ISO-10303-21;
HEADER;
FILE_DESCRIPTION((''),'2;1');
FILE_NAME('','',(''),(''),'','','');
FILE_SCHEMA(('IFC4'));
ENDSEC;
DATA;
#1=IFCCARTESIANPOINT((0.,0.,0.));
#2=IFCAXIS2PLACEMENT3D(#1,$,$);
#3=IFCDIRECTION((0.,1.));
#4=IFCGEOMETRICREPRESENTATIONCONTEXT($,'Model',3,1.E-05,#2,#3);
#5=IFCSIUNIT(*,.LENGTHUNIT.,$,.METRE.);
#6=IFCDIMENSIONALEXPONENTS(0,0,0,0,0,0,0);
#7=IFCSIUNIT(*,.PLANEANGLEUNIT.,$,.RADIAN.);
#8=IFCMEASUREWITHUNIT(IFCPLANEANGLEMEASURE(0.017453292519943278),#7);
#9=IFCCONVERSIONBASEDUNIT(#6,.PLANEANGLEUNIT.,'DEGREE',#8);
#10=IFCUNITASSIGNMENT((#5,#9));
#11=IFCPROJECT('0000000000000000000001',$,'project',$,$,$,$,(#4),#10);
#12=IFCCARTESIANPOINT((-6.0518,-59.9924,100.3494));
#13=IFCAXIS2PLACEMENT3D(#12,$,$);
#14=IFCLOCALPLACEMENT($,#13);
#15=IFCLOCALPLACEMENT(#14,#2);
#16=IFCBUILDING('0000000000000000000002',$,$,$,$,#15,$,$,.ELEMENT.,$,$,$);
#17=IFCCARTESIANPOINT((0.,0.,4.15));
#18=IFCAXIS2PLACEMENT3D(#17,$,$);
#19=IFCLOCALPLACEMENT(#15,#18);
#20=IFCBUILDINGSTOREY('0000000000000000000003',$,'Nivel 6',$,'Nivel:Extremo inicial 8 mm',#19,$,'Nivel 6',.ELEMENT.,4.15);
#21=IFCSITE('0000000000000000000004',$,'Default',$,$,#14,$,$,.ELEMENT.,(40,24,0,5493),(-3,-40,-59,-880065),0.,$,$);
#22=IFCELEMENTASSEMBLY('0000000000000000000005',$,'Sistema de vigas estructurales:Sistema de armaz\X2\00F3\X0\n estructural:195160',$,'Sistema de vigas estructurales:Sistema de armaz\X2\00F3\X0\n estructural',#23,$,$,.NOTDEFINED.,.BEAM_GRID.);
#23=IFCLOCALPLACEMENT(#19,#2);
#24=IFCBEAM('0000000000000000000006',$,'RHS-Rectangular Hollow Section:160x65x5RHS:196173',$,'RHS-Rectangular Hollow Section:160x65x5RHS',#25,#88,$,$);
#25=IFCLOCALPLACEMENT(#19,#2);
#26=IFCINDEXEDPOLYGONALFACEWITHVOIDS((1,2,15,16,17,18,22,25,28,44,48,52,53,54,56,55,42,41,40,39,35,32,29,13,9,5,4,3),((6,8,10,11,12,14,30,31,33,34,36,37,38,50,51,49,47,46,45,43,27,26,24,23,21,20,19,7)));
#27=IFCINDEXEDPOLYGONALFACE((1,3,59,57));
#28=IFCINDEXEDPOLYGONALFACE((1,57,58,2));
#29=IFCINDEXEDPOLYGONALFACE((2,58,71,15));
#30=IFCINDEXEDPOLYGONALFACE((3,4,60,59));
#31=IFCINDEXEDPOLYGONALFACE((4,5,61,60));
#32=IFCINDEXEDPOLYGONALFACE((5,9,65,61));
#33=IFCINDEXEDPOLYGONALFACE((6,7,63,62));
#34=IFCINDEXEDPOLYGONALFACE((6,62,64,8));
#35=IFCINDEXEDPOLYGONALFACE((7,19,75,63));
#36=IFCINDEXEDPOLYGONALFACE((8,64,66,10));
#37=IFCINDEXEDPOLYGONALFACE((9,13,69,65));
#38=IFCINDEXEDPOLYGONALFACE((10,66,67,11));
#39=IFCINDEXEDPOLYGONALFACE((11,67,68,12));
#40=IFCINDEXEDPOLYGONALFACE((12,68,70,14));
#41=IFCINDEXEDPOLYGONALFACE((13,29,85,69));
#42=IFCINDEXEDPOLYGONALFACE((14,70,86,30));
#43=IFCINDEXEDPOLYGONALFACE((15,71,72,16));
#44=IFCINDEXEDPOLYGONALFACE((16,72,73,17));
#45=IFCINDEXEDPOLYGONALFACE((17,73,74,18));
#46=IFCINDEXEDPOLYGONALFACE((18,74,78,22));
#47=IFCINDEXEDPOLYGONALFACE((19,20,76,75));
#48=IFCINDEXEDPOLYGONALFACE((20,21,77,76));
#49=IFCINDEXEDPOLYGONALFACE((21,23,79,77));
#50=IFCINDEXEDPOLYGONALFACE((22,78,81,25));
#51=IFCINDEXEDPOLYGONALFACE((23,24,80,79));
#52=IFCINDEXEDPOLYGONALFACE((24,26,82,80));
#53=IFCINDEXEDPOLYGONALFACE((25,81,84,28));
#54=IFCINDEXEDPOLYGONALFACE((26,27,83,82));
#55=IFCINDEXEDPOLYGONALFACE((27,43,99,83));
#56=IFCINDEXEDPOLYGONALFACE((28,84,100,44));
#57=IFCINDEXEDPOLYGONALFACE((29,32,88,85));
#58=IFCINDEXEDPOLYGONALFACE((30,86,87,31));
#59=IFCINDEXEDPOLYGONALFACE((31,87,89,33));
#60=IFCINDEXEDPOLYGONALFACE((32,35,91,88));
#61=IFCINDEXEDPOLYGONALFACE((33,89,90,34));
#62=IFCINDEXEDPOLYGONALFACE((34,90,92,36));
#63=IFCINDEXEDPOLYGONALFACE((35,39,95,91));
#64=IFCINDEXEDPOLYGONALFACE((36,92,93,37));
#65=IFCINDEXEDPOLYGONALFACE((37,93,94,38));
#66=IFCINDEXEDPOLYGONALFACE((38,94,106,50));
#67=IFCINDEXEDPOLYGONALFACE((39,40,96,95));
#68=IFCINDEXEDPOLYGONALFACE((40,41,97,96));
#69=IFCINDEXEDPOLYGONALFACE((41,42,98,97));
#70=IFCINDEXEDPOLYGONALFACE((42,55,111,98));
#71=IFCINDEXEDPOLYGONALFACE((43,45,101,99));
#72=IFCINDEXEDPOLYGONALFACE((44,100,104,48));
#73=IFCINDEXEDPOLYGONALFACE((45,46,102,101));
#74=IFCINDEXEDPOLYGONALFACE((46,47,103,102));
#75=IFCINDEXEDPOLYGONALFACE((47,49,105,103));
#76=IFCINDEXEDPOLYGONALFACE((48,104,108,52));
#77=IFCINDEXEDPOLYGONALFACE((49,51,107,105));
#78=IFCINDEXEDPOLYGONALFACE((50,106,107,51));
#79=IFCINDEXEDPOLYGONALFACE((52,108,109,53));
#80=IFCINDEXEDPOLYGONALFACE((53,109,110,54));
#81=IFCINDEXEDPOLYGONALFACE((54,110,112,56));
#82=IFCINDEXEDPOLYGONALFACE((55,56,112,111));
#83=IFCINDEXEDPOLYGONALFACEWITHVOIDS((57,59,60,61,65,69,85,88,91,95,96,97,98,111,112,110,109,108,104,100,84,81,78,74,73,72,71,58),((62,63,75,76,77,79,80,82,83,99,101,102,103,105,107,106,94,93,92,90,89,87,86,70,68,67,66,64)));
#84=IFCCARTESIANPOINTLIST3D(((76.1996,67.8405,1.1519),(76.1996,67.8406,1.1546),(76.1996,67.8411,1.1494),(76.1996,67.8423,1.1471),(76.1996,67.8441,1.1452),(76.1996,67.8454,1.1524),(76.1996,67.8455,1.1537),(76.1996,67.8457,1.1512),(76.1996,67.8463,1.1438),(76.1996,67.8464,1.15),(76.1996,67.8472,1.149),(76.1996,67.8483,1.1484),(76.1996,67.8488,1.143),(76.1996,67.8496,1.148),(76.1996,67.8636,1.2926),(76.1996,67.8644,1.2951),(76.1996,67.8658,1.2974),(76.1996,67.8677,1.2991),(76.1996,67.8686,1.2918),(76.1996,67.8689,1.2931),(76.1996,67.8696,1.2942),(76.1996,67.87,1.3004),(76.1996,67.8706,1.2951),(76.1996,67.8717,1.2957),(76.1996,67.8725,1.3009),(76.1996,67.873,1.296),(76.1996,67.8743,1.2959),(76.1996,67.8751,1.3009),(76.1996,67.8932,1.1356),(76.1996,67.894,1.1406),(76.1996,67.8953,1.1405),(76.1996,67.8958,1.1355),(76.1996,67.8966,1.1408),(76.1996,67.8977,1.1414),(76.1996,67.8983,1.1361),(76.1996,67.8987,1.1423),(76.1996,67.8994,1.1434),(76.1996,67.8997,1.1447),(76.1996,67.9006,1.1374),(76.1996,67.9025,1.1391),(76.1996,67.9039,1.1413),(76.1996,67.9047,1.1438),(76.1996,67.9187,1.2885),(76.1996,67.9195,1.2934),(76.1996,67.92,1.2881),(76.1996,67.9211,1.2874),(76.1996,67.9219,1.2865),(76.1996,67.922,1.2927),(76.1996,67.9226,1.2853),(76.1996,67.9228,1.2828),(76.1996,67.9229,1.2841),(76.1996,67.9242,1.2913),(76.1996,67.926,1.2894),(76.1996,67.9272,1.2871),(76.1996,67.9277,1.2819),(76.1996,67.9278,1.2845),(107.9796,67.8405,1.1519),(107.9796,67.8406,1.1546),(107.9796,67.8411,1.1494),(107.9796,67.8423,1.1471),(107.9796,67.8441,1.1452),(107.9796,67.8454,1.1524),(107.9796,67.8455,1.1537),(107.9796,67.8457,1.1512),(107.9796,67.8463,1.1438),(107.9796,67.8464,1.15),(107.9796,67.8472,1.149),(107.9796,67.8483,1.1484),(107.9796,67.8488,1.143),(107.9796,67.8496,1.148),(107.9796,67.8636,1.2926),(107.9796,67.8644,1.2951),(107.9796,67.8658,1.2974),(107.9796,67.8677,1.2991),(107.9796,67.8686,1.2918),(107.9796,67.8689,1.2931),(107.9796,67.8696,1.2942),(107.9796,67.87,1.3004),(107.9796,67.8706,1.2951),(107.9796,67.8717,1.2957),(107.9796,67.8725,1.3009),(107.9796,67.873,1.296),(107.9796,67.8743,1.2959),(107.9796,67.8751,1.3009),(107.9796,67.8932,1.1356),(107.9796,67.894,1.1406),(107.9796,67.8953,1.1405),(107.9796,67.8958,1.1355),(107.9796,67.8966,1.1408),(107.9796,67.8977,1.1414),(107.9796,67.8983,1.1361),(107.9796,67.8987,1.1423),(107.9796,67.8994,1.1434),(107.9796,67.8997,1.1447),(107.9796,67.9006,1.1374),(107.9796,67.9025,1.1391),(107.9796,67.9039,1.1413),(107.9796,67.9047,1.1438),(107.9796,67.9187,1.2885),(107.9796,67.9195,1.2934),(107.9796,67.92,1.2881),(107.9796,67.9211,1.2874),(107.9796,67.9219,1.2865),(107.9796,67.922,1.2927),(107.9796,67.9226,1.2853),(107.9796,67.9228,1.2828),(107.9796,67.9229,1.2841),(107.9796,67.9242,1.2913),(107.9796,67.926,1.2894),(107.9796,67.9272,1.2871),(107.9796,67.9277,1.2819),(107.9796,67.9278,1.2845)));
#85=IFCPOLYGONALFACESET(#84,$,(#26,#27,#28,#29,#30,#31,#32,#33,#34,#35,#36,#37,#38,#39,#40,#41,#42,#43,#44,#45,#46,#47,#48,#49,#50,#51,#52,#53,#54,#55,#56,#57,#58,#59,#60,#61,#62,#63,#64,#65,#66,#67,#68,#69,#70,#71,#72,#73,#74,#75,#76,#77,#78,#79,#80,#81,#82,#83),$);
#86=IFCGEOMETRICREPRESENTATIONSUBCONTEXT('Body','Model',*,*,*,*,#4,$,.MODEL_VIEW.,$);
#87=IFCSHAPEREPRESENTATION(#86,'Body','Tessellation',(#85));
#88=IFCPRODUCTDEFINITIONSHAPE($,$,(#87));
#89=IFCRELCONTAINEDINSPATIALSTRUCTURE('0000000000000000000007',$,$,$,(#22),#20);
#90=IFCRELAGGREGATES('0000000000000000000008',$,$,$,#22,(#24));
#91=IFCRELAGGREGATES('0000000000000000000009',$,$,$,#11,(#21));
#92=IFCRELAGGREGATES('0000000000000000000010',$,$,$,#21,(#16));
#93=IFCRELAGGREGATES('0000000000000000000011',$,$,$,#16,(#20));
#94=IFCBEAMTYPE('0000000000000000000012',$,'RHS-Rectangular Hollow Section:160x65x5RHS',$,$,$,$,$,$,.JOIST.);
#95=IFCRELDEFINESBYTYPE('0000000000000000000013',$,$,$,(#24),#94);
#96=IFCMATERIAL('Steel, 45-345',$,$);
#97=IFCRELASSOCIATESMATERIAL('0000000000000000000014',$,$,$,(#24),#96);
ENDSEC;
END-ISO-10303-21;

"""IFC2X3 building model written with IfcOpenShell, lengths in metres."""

from ifc_helpers import new_model, entity, si_unit, converted_unit, direction, frame, frame_2d, origin, place, context, subcontext, project, spatial, polyline, circle_curve, parameter, trimmed, segment, composite_curve, outline, extrude, material, type_object, element, aggregate, save


model = new_model("IFC2X3")

# Units and contexts
model_context = context("Model", 3, precision=1e-05, world=origin(), true_north=direction((0.0, 1.0)))
body_context = subcontext(model_context, "Body", "Model", "MODEL_VIEW")
ifc_project = project(units=[si_unit("LENGTHUNIT", "METRE"), converted_unit("PLANEANGLEUNIT", "DEGREE", entity("IfcPlaneAngleMeasure", 0.017453292519943278), si_unit("PLANEANGLEUNIT", "RADIAN"), dimensions=[0, 0, 0, 0, 0, 0, 0])], contexts=[model_context])

# Site, building, storey
site_placement = place(None, frame((-6.0518, -59.9924, 100.3494)))
site = spatial("IfcSite", under=ifc_project, at=site_placement, Name="Default", CompositionType="ELEMENT", RefLatitude=(40, 24, 0, 5493), RefLongitude=(-3, -40, -59, -880065), RefElevation=0.0)
building_placement = place(site_placement, origin())
building = spatial("IfcBuilding", under=site, at=building_placement, CompositionType="ELEMENT")
storey_placement = place(building_placement, frame((0.0, 0.0, 4.15)))
storey = spatial("IfcBuildingStorey", under=building, at=storey_placement, Name="Nivel 6", ObjectType="Nivel:Extremo inicial 8 mm", LongName="Nivel 6", CompositionType="ELEMENT", Elevation=4.15)

# Shared definitions
ifc_material_1 = material(Name="Steel, 45-345")

# Element assembly, beam
assembly_placement = place(storey_placement, origin())
assembly = element("IfcElementAssembly", 1, at=assembly_placement, inside=storey, Name="Sistema de vigas estructurales:Sistema de armazón estructural:195160", ObjectType="Sistema de vigas estructurales:Sistema de armazón estructural", AssemblyPlace="NOTDEFINED", PredefinedType="BEAM_GRID")
beam_type_1 = type_object("IfcBeamType", Name="RHS-Rectangular Hollow Section:160x65x5RHS", PredefinedType="JOIST")
beam_1_placement = place(assembly_placement, frame((107.9796, 67.8446, 0.9815), z_axis=(0.0, 0.0, 1.0), x_axis=(-1.0, 0.0, 0.0)))
beam_1 = element("IfcBeam", 2, at=beam_1_placement, type_object=beam_type_1, material=ifc_material_1, Name="RHS-Rectangular Hollow Section:160x65x5RHS:196173", ObjectType="RHS-Rectangular Hollow Section:160x65x5RHS", context=body_context, shape_type="SweptSolid", body=[
    extrude(outline(composite_curve([segment(trimmed(circle_curve(frame_2d((-0.0225, -0.07), x_axis=(1.0, 0.0)), 0.01), [parameter(180.0)], [parameter(270.0)], True, "PARAMETER"), True, "CONTINUOUS"), segment(polyline([(-0.0225, -0.08), (0.0225, -0.08)]), True, "CONTINUOUS"), segment(trimmed(circle_curve(frame_2d((0.0225, -0.07), x_axis=(1.0, 0.0)), 0.01), [parameter(270.0)], [parameter(0.0)], True, "PARAMETER"), True, "CONTINUOUS"), segment(polyline([(0.0325, -0.07), (0.0325, 0.07)]), True, "CONTINUOUS"), segment(trimmed(circle_curve(frame_2d((0.0225, 0.07), x_axis=(1.0, 0.0)), 0.01), [parameter(360.0)], [parameter(90.0)], True, "PARAMETER"), True, "CONTINUOUS"), segment(polyline([(0.0225, 0.08), (-0.0225, 0.08)]), True, "CONTINUOUS"), segment(trimmed(circle_curve(frame_2d((-0.0225, 0.07), x_axis=(1.0, 0.0)), 0.01), [parameter(90.0)], [parameter(180.0)], True, "PARAMETER"), True, "CONTINUOUS"), segment(polyline([(-0.0325, 0.07), (-0.0325, -0.07)]), True, "CONTINUOUS")], self_intersect=False), holes=[composite_curve([segment(polyline([(0.0225, -0.075), (-0.0225, -0.075)]), True, "CONTINUOUS"), segment(trimmed(circle_curve(frame_2d((-0.0225, -0.07), x_axis=(1.0, 0.0)), 0.005), [parameter(180.0)], [parameter(270.0)], True, "PARAMETER"), False, "CONTINUOUS"), segment(polyline([(-0.0275, -0.07), (-0.0275, 0.07)]), True, "CONTINUOUS"), segment(trimmed(circle_curve(frame_2d((-0.0225, 0.07), x_axis=(1.0, 0.0)), 0.005), [parameter(90.0)], [parameter(180.0)], True, "PARAMETER"), False, "CONTINUOUS"), segment(polyline([(-0.0225, 0.075), (0.0225, 0.075)]), True, "CONTINUOUS"), segment(trimmed(circle_curve(frame_2d((0.0225, 0.07), x_axis=(1.0, 0.0)), 0.005), [parameter(0.0)], [parameter(90.0)], True, "PARAMETER"), False, "CONTINUOUS"), segment(polyline([(0.0275, 0.07), (0.0275, -0.07)]), True, "CONTINUOUS"), segment(trimmed(circle_curve(frame_2d((0.0225, -0.07), x_axis=(1.0, 0.0)), 0.005), [parameter(270.0)], [parameter(0.0)], True, "PARAMETER"), False, "CONTINUOUS")], self_intersect=False)]), frame((0.0, -0.0396, 0.2367), z_axis=(1.0, 0.0, 0.0), x_axis=(0.0, -0.986325, -0.16481)), (0.0, 0.0, 1.0), 31.78),
])
aggregate(assembly, [beam_1])

save(model, "model.ifc")
